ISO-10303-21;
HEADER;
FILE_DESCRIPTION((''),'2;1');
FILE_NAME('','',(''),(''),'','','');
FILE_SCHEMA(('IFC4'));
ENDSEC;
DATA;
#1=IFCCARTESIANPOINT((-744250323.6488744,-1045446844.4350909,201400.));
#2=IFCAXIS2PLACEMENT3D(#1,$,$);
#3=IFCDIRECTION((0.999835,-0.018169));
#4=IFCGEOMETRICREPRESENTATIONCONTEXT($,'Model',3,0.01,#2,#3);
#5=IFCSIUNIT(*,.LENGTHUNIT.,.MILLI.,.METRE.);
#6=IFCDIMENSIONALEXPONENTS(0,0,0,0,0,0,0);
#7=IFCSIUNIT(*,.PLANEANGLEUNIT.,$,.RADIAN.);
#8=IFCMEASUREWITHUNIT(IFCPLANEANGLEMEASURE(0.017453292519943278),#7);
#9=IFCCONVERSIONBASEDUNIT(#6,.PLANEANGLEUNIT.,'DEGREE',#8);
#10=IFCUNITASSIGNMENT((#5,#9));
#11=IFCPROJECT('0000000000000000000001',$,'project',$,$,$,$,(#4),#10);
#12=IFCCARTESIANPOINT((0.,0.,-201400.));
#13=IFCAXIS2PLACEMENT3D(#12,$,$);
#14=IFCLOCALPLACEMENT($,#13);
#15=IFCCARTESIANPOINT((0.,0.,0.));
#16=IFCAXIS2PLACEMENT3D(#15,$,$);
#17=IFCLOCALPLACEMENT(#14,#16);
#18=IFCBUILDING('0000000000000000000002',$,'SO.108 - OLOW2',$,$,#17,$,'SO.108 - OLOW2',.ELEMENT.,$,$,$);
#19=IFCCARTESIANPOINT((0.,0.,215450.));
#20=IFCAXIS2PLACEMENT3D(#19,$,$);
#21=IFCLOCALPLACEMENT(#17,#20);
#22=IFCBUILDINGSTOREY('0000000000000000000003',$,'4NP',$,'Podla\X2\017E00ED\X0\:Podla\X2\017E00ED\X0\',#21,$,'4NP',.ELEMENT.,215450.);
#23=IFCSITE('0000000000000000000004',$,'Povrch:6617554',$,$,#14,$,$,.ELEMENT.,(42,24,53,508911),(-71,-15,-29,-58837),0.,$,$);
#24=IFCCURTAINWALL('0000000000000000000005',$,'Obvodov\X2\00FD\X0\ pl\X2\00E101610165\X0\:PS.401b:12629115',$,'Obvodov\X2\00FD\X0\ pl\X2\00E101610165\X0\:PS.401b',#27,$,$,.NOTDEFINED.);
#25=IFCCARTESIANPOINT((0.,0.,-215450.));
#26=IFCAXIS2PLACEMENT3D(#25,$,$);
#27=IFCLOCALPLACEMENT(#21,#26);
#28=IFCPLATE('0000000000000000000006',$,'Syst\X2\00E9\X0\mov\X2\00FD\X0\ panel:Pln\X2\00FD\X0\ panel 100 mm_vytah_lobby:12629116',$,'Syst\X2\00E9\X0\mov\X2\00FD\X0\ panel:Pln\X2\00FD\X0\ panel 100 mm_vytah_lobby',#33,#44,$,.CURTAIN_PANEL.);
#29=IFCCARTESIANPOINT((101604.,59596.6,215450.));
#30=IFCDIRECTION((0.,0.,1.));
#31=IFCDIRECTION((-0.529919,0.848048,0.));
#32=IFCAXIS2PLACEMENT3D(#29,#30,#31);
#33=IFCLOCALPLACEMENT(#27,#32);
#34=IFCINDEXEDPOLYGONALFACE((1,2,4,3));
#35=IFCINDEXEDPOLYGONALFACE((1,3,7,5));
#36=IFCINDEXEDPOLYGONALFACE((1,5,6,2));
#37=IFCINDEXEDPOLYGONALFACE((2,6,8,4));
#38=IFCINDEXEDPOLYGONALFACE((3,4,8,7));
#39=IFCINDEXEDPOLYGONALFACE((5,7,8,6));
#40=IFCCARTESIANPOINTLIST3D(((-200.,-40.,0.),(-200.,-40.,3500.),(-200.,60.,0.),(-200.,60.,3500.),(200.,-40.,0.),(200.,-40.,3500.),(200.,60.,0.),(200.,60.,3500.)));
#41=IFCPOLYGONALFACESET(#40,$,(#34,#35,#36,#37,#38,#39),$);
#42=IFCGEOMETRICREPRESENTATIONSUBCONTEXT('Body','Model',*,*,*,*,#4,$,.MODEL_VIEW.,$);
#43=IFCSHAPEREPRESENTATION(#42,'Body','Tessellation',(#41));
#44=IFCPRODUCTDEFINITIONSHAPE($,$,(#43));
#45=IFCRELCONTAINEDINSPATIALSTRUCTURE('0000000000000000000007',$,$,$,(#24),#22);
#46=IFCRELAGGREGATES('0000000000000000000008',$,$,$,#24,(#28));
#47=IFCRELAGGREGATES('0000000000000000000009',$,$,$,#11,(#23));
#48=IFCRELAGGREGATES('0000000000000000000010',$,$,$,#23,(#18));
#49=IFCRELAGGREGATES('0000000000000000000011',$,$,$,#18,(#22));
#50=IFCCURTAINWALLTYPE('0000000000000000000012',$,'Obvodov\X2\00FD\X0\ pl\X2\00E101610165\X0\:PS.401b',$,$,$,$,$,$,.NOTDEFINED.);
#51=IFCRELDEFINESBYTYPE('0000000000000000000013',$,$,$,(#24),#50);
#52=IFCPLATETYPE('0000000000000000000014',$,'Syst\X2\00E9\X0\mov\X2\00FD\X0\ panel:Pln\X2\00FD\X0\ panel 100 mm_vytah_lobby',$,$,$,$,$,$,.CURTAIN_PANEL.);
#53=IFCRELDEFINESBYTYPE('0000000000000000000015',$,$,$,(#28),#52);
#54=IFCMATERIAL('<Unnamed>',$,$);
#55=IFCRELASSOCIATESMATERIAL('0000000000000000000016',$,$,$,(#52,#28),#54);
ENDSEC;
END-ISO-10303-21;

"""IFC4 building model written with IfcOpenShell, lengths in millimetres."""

from ifc_helpers import new_model, entity, si_unit, converted_unit, direction, frame, origin, place, context, subcontext, project, spatial, indexed_curve, outline, extrude, source, transform, mapped, material, type_object, type_shapes, element, aggregate, save


model = new_model("IFC4")

# Units and contexts
model_context = context("Model", 3, precision=0.01, world=frame((-744250323.6488744, -1045446844.4350909, 201400.0)), true_north=direction((0.999835, -0.018169)))
body_context = subcontext(model_context, "Body", "Model", "MODEL_VIEW")
ifc_project = project(units=[si_unit("LENGTHUNIT", "METRE", prefix="MILLI"), converted_unit("PLANEANGLEUNIT", "DEGREE", entity("IfcPlaneAngleMeasure", 0.017453292519943278), si_unit("PLANEANGLEUNIT", "RADIAN"), dimensions=[0, 0, 0, 0, 0, 0, 0])], contexts=[model_context])

# Site, building, storey
site_placement = place(None, frame((0.0, 0.0, -201400.0)))
site = spatial("IfcSite", under=ifc_project, at=site_placement, Name="Povrch:6617554", CompositionType="ELEMENT", RefLatitude=(42, 24, 53, 508911), RefLongitude=(-71, -15, -29, -58837), RefElevation=0.0)
building_placement = place(site_placement, origin())
building = spatial("IfcBuilding", under=site, at=building_placement, Name="SO.108 - OLOW2", LongName="SO.108 - OLOW2", CompositionType="ELEMENT")
storey_placement = place(building_placement, frame((0.0, 0.0, 215450.0)))
storey = spatial("IfcBuildingStorey", under=building, at=storey_placement, Name="4NP", ObjectType="Podlaží:Podlaží", LongName="4NP", CompositionType="ELEMENT", Elevation=215450.0)

# Shared definitions
ifc_material_1 = material(Name="<Unnamed>")

# Curtain wall
curtain_wall_type_1 = type_object("IfcCurtainWallType", Name="Obvodový plášť:PS.401b", PredefinedType="NOTDEFINED")
curtain_wall_1_placement = place(storey_placement, frame((0.0, 0.0, -215450.0)))
curtain_wall_1 = element("IfcCurtainWall", 1, at=curtain_wall_1_placement, inside=storey, type_object=curtain_wall_type_1, Name="Obvodový plášť:PS.401b:12629115", ObjectType="Obvodový plášť:PS.401b", PredefinedType="NOTDEFINED")

# Plate
plate_type_1 = type_object("IfcPlateType", Name="Systémový panel:Plný panel 100 mm_vytah_lobby", PredefinedType="CURTAIN_PANEL", material=ifc_material_1)
shared_shape_1 = source(origin(), body_context, "Body", "SweptSolid", [
    extrude(outline(indexed_curve([(-50.0, -200.0), (50.0, -200.0), (50.0, 200.0), (-50.0, 200.0), (-50.0, -200.0)], self_intersect=False)), frame((0.0, 10.0, 0.0), z_axis=(0.0, 0.0, 1.0), x_axis=(0.0, 1.0, 0.0)), (0.0, 0.0, 1.0), 3500.0),
])
type_shapes(plate_type_1, [shared_shape_1])
plate_1_placement = place(curtain_wall_1_placement, frame((101604.0, 59596.6, 215450.0), z_axis=(0.0, 0.0, 1.0), x_axis=(-0.529919, 0.848048, 0.0)))
plate_1 = element("IfcPlate", 2, at=plate_1_placement, type_object=plate_type_1, material=ifc_material_1, Name="Systémový panel:Plný panel 100 mm_vytah_lobby:12629116", ObjectType="Systémový panel:Plný panel 100 mm_vytah_lobby", PredefinedType="CURTAIN_PANEL", context=body_context, shape_type="MappedRepresentation", body=[
    mapped(shared_shape_1, transform((0.0, 0.0, 0.0), scale=1.0)),
])
aggregate(curtain_wall_1, [plate_1])

save(model, "model.ifc")
